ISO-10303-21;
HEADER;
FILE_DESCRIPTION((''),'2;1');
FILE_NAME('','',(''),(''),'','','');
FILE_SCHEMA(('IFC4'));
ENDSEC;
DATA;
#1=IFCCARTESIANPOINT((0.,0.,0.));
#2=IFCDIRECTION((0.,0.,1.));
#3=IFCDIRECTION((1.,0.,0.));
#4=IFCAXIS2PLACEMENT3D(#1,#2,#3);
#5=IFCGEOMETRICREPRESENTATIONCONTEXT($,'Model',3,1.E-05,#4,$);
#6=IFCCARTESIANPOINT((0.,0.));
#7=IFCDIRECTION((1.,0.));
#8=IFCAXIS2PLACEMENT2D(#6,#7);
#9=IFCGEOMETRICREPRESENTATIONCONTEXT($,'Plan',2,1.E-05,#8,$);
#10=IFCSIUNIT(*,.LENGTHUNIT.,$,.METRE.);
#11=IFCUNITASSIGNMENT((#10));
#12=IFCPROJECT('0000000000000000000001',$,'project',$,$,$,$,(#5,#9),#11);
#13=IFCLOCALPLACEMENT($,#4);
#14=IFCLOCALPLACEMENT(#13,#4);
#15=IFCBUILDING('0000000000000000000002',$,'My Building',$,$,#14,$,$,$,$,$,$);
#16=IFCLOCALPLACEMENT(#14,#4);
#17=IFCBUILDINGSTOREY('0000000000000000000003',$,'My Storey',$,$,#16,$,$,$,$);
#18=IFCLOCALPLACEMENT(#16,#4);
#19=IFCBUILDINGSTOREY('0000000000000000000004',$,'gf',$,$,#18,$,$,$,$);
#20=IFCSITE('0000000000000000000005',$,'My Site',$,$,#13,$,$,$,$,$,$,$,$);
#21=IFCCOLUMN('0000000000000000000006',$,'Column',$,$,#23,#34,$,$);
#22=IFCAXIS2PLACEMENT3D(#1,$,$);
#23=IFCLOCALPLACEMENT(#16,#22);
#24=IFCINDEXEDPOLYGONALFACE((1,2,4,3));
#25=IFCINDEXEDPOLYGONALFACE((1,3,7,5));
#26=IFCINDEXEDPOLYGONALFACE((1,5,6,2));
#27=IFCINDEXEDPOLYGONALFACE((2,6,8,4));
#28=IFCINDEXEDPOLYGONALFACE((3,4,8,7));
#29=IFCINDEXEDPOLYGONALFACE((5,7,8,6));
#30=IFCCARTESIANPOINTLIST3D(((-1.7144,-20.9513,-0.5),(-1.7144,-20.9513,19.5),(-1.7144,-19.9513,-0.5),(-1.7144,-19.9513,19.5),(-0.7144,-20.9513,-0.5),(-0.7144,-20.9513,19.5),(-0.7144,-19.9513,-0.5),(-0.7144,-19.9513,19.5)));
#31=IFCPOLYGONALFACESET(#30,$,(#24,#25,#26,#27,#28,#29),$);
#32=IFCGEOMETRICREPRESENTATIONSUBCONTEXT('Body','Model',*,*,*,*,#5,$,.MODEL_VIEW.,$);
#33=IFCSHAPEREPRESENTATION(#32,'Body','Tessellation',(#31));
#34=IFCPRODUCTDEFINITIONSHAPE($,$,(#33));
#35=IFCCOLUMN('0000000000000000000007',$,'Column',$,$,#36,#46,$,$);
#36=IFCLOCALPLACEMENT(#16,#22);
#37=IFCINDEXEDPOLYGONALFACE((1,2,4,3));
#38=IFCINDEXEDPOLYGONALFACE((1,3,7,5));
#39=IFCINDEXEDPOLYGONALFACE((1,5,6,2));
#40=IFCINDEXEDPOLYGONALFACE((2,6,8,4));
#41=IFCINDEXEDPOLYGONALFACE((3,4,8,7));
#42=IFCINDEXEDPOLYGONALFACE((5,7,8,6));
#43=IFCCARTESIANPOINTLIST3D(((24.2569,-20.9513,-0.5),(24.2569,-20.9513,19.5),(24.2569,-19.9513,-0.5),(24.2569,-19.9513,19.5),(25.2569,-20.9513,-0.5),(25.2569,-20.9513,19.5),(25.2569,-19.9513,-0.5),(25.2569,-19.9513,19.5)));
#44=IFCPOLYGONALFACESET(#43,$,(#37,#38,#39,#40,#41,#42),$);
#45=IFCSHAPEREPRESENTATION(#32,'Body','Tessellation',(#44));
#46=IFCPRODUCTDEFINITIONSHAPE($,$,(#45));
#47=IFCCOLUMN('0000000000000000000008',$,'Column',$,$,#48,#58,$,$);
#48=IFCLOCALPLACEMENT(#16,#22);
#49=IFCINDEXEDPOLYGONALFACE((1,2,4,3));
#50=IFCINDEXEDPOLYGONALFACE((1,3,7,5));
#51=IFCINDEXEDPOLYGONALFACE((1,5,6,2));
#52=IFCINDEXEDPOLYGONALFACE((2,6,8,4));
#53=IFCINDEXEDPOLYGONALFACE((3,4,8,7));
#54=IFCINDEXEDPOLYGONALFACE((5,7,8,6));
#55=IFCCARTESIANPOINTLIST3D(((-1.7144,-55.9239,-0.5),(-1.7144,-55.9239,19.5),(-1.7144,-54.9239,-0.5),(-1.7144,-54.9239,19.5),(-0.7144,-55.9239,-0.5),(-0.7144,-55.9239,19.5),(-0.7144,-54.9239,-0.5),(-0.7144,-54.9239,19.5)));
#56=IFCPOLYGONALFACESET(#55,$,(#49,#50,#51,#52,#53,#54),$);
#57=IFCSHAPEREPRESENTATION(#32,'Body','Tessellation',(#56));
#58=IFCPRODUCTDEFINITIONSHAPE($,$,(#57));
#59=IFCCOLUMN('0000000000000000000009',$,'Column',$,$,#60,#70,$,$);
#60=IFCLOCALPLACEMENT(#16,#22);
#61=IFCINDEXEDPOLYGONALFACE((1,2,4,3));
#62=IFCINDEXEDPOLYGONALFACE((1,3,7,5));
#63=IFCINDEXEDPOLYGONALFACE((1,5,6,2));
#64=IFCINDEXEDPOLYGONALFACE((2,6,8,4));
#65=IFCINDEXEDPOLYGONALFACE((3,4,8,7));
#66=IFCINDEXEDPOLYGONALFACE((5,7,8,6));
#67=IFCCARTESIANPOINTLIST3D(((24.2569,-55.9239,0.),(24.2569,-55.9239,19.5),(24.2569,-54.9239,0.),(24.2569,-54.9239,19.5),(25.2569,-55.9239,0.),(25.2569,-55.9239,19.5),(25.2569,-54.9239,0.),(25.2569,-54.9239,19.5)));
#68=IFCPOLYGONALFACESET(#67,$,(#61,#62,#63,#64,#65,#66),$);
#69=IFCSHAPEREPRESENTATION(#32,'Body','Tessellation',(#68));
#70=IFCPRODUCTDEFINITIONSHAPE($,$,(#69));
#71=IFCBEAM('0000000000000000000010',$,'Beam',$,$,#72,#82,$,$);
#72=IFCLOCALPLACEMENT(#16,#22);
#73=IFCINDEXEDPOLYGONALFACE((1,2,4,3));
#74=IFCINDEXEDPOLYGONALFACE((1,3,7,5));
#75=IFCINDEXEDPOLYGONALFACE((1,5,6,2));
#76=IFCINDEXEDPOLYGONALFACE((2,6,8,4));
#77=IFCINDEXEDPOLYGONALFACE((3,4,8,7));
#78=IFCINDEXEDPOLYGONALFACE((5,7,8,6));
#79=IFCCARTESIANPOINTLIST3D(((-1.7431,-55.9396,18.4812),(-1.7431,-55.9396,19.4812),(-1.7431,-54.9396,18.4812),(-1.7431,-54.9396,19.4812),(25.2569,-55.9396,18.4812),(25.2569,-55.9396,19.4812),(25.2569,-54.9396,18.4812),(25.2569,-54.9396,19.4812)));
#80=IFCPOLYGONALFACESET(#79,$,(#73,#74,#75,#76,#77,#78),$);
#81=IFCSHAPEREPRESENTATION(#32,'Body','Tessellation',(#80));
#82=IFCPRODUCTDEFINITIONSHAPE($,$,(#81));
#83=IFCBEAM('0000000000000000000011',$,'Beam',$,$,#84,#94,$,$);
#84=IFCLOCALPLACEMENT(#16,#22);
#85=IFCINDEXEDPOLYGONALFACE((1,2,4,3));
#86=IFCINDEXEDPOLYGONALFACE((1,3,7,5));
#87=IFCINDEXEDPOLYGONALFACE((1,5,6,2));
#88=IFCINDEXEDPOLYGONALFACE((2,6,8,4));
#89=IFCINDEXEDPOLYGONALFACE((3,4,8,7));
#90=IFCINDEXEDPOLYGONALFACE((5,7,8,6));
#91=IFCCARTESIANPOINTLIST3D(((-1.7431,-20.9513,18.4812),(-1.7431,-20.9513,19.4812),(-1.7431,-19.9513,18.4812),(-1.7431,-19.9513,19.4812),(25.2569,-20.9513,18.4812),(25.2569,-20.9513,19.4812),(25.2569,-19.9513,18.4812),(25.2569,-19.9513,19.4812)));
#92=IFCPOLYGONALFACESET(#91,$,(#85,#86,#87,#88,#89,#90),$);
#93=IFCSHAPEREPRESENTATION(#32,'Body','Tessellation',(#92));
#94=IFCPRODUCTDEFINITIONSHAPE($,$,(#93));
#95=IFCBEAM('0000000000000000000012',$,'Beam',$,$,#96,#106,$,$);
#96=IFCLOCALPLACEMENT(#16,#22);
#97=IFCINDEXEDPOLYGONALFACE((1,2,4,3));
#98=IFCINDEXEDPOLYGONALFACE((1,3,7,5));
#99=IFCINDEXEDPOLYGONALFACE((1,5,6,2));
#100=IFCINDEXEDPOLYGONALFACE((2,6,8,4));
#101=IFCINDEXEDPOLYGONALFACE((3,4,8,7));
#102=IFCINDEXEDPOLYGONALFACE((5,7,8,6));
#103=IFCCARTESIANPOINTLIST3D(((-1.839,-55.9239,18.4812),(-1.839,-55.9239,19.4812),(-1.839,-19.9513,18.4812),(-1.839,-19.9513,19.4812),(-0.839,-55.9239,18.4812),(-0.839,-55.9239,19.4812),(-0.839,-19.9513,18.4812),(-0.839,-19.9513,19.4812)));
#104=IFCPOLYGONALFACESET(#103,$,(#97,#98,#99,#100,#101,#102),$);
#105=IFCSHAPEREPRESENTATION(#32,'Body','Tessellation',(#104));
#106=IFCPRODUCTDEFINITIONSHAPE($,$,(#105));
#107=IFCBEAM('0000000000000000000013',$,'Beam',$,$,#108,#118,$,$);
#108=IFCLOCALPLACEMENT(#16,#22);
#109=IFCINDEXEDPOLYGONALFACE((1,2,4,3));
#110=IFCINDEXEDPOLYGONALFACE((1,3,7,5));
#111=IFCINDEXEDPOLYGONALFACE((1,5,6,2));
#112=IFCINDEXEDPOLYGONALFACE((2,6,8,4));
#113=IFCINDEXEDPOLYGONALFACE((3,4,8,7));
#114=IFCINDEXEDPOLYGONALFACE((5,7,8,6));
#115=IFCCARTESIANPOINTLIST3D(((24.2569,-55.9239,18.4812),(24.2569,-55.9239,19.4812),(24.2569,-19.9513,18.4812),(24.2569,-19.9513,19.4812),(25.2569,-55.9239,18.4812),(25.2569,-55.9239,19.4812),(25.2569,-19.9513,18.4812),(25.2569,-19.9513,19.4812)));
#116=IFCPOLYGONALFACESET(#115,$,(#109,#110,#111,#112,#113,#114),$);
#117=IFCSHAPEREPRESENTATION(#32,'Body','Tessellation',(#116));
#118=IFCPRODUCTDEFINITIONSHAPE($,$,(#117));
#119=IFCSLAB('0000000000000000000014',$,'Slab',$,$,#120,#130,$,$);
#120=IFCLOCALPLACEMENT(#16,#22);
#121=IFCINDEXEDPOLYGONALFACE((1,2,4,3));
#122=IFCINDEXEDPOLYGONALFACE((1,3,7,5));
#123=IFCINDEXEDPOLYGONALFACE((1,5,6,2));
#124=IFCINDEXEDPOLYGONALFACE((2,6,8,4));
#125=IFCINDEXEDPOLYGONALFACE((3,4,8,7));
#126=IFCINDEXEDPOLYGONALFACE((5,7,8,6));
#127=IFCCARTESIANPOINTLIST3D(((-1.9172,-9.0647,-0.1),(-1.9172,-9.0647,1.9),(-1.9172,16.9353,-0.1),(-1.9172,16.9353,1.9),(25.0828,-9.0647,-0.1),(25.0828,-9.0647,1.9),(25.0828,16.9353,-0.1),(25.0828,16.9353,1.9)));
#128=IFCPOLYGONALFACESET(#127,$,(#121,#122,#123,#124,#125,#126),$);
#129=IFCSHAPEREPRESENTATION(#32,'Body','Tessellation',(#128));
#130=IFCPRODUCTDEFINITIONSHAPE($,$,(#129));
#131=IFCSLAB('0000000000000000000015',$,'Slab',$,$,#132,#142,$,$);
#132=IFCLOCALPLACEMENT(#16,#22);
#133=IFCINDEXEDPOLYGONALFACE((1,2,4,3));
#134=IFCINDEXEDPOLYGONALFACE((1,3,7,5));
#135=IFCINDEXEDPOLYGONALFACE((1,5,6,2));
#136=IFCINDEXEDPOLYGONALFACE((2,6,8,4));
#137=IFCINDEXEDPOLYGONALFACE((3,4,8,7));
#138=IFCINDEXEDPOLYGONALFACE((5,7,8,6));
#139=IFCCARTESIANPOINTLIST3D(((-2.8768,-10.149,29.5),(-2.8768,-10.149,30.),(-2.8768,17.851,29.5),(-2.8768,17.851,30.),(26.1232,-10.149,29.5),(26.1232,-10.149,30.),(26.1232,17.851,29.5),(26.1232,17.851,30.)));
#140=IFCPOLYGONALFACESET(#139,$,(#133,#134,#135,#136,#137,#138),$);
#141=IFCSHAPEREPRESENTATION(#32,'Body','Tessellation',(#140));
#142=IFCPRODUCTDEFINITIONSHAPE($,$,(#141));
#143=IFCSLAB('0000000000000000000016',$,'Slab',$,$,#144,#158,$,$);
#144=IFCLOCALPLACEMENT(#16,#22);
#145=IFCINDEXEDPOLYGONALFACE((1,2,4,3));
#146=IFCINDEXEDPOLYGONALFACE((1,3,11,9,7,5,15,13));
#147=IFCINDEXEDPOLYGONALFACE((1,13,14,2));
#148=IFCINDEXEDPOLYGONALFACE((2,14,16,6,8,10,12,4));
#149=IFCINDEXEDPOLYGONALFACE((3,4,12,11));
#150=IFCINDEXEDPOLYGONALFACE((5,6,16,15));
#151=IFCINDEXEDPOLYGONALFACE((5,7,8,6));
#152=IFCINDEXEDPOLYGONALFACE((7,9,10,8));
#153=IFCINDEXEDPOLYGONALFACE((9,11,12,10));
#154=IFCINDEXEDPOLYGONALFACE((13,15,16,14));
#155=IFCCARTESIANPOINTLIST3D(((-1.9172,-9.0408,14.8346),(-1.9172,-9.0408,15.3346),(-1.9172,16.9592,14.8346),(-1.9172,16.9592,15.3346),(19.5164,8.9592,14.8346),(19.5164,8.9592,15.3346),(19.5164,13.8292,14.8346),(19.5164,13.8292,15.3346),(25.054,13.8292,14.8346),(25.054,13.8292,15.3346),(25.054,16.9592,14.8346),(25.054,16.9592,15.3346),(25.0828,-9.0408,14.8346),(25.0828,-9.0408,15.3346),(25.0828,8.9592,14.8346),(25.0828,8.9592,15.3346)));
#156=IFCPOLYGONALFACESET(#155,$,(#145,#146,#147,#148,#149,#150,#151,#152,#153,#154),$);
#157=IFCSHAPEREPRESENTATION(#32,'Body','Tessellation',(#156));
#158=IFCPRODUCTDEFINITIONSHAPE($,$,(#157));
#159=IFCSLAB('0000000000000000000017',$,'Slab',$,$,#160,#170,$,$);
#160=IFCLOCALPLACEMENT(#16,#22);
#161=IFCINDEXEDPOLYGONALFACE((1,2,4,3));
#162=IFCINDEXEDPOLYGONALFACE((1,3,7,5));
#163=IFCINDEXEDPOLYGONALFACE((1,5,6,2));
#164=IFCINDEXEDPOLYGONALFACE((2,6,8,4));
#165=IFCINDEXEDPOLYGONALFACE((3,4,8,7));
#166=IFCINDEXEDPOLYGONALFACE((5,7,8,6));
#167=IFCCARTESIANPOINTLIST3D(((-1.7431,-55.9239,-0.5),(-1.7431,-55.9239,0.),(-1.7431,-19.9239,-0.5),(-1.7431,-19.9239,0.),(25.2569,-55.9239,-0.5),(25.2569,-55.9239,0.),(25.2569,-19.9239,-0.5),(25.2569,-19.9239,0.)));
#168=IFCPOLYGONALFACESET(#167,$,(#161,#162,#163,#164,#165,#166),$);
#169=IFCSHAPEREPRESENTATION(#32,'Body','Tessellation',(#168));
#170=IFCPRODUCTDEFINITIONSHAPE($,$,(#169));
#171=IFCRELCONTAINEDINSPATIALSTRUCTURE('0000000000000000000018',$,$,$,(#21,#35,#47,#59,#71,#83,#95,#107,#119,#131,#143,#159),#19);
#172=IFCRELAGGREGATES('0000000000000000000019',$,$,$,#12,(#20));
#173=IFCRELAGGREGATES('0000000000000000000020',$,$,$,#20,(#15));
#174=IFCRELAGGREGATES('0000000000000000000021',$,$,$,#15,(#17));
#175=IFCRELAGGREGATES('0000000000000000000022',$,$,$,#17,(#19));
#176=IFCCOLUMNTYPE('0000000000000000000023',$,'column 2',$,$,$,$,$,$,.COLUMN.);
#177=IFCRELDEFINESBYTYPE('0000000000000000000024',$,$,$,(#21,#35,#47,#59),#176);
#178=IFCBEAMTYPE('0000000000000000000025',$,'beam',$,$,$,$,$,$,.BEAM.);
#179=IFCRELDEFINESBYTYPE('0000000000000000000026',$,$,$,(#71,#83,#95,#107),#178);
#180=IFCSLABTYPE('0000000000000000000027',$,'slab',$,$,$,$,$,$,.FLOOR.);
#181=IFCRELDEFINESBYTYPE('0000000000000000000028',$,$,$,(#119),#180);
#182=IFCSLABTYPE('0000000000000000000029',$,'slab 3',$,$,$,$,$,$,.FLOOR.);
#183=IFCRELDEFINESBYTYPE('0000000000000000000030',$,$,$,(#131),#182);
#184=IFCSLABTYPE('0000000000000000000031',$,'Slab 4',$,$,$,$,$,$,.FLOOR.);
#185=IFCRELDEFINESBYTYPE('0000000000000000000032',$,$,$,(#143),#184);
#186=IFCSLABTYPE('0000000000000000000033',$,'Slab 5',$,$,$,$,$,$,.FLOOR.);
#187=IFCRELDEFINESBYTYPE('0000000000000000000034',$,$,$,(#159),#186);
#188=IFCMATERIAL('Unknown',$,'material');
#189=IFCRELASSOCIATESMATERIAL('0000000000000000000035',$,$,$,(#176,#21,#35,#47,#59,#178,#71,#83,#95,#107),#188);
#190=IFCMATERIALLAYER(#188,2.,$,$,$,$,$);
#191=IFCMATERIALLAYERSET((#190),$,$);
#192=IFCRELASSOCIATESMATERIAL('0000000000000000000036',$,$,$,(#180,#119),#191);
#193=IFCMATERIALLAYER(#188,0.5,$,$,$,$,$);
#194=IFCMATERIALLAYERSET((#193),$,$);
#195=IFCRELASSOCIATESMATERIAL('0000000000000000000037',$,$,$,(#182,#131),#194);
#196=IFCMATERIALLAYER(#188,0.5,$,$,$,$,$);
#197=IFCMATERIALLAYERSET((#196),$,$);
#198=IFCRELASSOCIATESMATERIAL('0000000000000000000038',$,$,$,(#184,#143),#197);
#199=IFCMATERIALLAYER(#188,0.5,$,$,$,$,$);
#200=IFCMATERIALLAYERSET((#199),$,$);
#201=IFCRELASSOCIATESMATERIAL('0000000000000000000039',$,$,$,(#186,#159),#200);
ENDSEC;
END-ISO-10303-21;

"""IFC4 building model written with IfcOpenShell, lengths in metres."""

from ifc_helpers import new_model, si_unit, frame, origin_with_axes, origin_2d_with_axis, place, context, subcontext, project, spatial, indexed_curve, rectangle, outline, extrude, material, layer, layer_set, layer_usage, material_profile, profile_set, profile_usage, type_object, element, save


model = new_model("IFC4")

# Units and contexts
model_context = context("Model", 3, precision=1e-05, world=origin_with_axes())
plan_context = context("Plan", 2, precision=1e-05, world=origin_2d_with_axis())
body_context_1 = subcontext(model_context, "Body", "Model", "MODEL_VIEW")
ifc_project = project(units=[si_unit("LENGTHUNIT", "METRE")], contexts=[model_context, plan_context])

# Site, building, storeys
site_placement = place(None, origin_with_axes())
site = spatial("IfcSite", under=ifc_project, at=site_placement, Name="My Site")
building_placement = place(site_placement, origin_with_axes())
building = spatial("IfcBuilding", under=site, at=building_placement, Name="My Building")
storey_1_placement = place(building_placement, origin_with_axes())
storey_1 = spatial("IfcBuildingStorey", under=building, at=storey_1_placement, Name="My Storey")
storey_2_placement = place(storey_1_placement, origin_with_axes())
storey_2 = spatial("IfcBuildingStorey", under=storey_1, at=storey_2_placement, Name="gf")

# Columns
ifc_material = material(Name="Unknown", Category="material")
ifc_material_profile_1 = material_profile(ifc_material, rectangle(XDim=1.0, YDim=1.0))
ifc_profile_set_1 = profile_set([ifc_material_profile_1])
ifc_profile_usage_1 = profile_usage(ifc_profile_set_1, cardinal=5)
column_type = type_object("IfcColumnType", Name="column 2", PredefinedType="COLUMN", material=ifc_profile_set_1)
column_1_placement = place(storey_2_placement, frame((-1.2144, -20.4513, -0.5), z_axis=(0.0, 0.0, 1.0), x_axis=(1.0, 0.0, 0.0)))
element("IfcColumn", 1, at=column_1_placement, inside=storey_2, type_object=column_type, material=ifc_profile_usage_1, Name="Column", context=body_context_1, shape_type="SweptSolid", body=[
    extrude(rectangle(XDim=1.0, YDim=1.0), origin_with_axes(), (0.0, 0.0, 1.0), 20.0),
])
ifc_profile_usage_2 = profile_usage(ifc_profile_set_1, cardinal=5)
column_2_placement = place(storey_2_placement, frame((24.7569, -20.4513, -0.5), z_axis=(0.0, 0.0, 1.0), x_axis=(1.0, 0.0, 0.0)))
element("IfcColumn", 2, at=column_2_placement, inside=storey_2, type_object=column_type, material=ifc_profile_usage_2, Name="Column", context=body_context_1, shape_type="SweptSolid", body=[
    extrude(rectangle(XDim=1.0, YDim=1.0), origin_with_axes(), (0.0, 0.0, 1.0), 20.0),
])
ifc_profile_usage_3 = profile_usage(ifc_profile_set_1, cardinal=5)
column_3_placement = place(storey_2_placement, frame((-1.2144, -55.4239, -0.5), z_axis=(0.0, 0.0, 1.0), x_axis=(1.0, 0.0, 0.0)))
element("IfcColumn", 3, at=column_3_placement, inside=storey_2, type_object=column_type, material=ifc_profile_usage_3, Name="Column", context=body_context_1, shape_type="SweptSolid", body=[
    extrude(rectangle(XDim=1.0, YDim=1.0), origin_with_axes(), (0.0, 0.0, 1.0), 20.0),
])
ifc_profile_usage_4 = profile_usage(ifc_profile_set_1, cardinal=5)
column_4_placement = place(storey_2_placement, frame((24.7569, -55.4239, 0.0), z_axis=(0.0, 0.0, 1.0), x_axis=(1.0, 0.0, 0.0)))
element("IfcColumn", 4, at=column_4_placement, inside=storey_2, type_object=column_type, material=ifc_profile_usage_4, Name="Column", context=body_context_1, shape_type="SweptSolid", body=[
    extrude(rectangle(XDim=1.0, YDim=1.0), origin_with_axes(), (0.0, 0.0, 1.0), 19.5),
])

# Beams
ifc_material_profile_2 = material_profile(ifc_material, rectangle(XDim=1.0, YDim=1.0))
ifc_profile_set_2 = profile_set([ifc_material_profile_2])
ifc_profile_usage_5 = profile_usage(ifc_profile_set_2, cardinal=5)
beam_type = type_object("IfcBeamType", Name="beam", PredefinedType="BEAM", material=ifc_profile_set_2)
beam_1_placement = place(storey_2_placement, frame((-1.7431, -55.4396, 18.9812), z_axis=(1.0, 0.0, 0.0), x_axis=(0.0, 1.0, 0.0)))
element("IfcBeam", 5, at=beam_1_placement, inside=storey_2, type_object=beam_type, material=ifc_profile_usage_5, Name="Beam", context=body_context_1, shape_type="SweptSolid", body=[
    extrude(rectangle(XDim=1.0, YDim=1.0), origin_with_axes(), (0.0, 0.0, 1.0), 27.0),
])
ifc_profile_usage_6 = profile_usage(ifc_profile_set_2, cardinal=5)
beam_2_placement = place(storey_2_placement, frame((-1.7431, -20.4513, 18.9812), z_axis=(1.0, 0.0, 0.0), x_axis=(0.0, 1.0, 0.0)))
element("IfcBeam", 6, at=beam_2_placement, inside=storey_2, type_object=beam_type, material=ifc_profile_usage_6, Name="Beam", context=body_context_1, shape_type="SweptSolid", body=[
    extrude(rectangle(XDim=1.0, YDim=1.0), origin_with_axes(), (0.0, 0.0, 1.0), 27.0),
])
ifc_profile_usage_7 = profile_usage(ifc_profile_set_2, cardinal=5)
beam_3_placement = place(storey_2_placement, frame((-1.339, -19.9513, 18.9812), z_axis=(0.0, -1.0, 0.0), x_axis=(1.0, 0.0, 0.0)))
element("IfcBeam", 7, at=beam_3_placement, inside=storey_2, type_object=beam_type, material=ifc_profile_usage_7, Name="Beam", context=body_context_1, shape_type="SweptSolid", body=[
    extrude(rectangle(XDim=1.0, YDim=1.0), origin_with_axes(), (0.0, 0.0, 1.0), 35.9726),
])
ifc_profile_usage_8 = profile_usage(ifc_profile_set_2, cardinal=5)
beam_4_placement = place(storey_2_placement, frame((24.7569, -19.9513, 18.9812), z_axis=(0.0, -1.0, 0.0), x_axis=(1.0, 0.0, 0.0)))
element("IfcBeam", 8, at=beam_4_placement, inside=storey_2, type_object=beam_type, material=ifc_profile_usage_8, Name="Beam", context=body_context_1, shape_type="SweptSolid", body=[
    extrude(rectangle(XDim=1.0, YDim=1.0), origin_with_axes(), (0.0, 0.0, 1.0), 35.9726),
])

# Slabs
ifc_layer_1 = layer(ifc_material, 2.0)
ifc_layer_set_1 = layer_set([ifc_layer_1])
ifc_layer_usage_1 = layer_usage(ifc_layer_set_1, "AXIS3", "POSITIVE", -0.1)
slab_type_1 = type_object("IfcSlabType", Name="slab", PredefinedType="FLOOR", material=ifc_layer_set_1)
slab_1_placement = place(storey_2_placement, frame((-1.9172, 16.9353, 0.0), z_axis=(0.0, 0.0, 1.0), x_axis=(1.0, 0.0, 0.0)))
element("IfcSlab", 9, at=slab_1_placement, inside=storey_2, type_object=slab_type_1, material=ifc_layer_usage_1, Name="Slab", context=body_context_1, shape_type="SweptSolid", body=[
    extrude(outline(indexed_curve([(0.0, 0.0), (0.0, -26.0), (27.0, -26.0), (27.0, 0.0), (0.0, 0.0)])), frame((0.0, 0.0, -0.1), z_axis=(0.0, 0.0, 1.0), x_axis=(1.0, 0.0, 0.0)), (0.0, 0.0, 1.0), 2.0),
])
ifc_layer_2 = layer(ifc_material, 0.5)
ifc_layer_set_2 = layer_set([ifc_layer_2])
ifc_layer_usage_2 = layer_usage(ifc_layer_set_2, "AXIS3", "POSITIVE", -0.5)
slab_type_2 = type_object("IfcSlabType", Name="slab 3", PredefinedType="FLOOR", material=ifc_layer_set_2)
slab_2_placement = place(storey_2_placement, frame((-2.8768, 17.851, 30.0), z_axis=(0.0, 0.0, 1.0), x_axis=(1.0, 0.0, 0.0)))
element("IfcSlab", 10, at=slab_2_placement, inside=storey_2, type_object=slab_type_2, material=ifc_layer_usage_2, Name="Slab", context=body_context_1, shape_type="SweptSolid", body=[
    extrude(outline(indexed_curve([(0.0, 0.0), (0.0, -28.0), (29.0, -28.0), (29.0, 0.0), (0.0, 0.0)])), frame((0.0, 0.0, -0.5), z_axis=(0.0, 0.0, 1.0), x_axis=(1.0, 0.0, 0.0)), (0.0, 0.0, 1.0), 0.5),
])
ifc_layer_3 = layer(ifc_material, 0.5)
ifc_layer_set_3 = layer_set([ifc_layer_3])
ifc_layer_usage_3 = layer_usage(ifc_layer_set_3, "AXIS3", "POSITIVE", -0.5)
slab_type_3 = type_object("IfcSlabType", Name="Slab 4", PredefinedType="FLOOR", material=ifc_layer_set_3)
slab_3_placement = place(storey_2_placement, frame((-1.9172, 16.9592, 15.3346), z_axis=(0.0, 0.0, 1.0), x_axis=(1.0, 0.0, 0.0)))
element("IfcSlab", 11, at=slab_3_placement, inside=storey_2, type_object=slab_type_3, material=ifc_layer_usage_3, Name="Slab", context=body_context_1, shape_type="SweptSolid", body=[
    extrude(outline(indexed_curve([(0.0, 0.0), (0.0, -26.0), (27.0, -26.0), (27.0, -8.0), (21.4336, -8.0), (21.4336, -3.13), (26.9711, -3.13), (26.9711, 0.0), (0.0, 0.0)])), frame((0.0, 0.0, -0.5), z_axis=(0.0, 0.0, 1.0), x_axis=(1.0, 0.0, 0.0)), (0.0, 0.0, 1.0), 0.5),
])
ifc_layer_4 = layer(ifc_material, 0.5)
ifc_layer_set_4 = layer_set([ifc_layer_4])
ifc_layer_usage_4 = layer_usage(ifc_layer_set_4, "AXIS3", "POSITIVE", -0.5)
slab_type_4 = type_object("IfcSlabType", Name="Slab 5", PredefinedType="FLOOR", material=ifc_layer_set_4)
slab_4_placement = place(storey_2_placement, frame((-1.7431, -19.9239, 0.0), z_axis=(0.0, 0.0, 1.0), x_axis=(1.0, 0.0, 0.0)))
element("IfcSlab", 12, at=slab_4_placement, inside=storey_2, type_object=slab_type_4, material=ifc_layer_usage_4, Name="Slab", context=body_context_1, shape_type="SweptSolid", body=[
    extrude(outline(indexed_curve([(0.0, 0.0), (0.0, -36.0), (27.0, -36.0), (27.0, 0.0), (0.0, 0.0)])), frame((0.0, 0.0, -0.5), z_axis=(0.0, 0.0, 1.0), x_axis=(1.0, 0.0, 0.0)), (0.0, 0.0, 1.0), 0.5),
])

save(model, "model.ifc")
